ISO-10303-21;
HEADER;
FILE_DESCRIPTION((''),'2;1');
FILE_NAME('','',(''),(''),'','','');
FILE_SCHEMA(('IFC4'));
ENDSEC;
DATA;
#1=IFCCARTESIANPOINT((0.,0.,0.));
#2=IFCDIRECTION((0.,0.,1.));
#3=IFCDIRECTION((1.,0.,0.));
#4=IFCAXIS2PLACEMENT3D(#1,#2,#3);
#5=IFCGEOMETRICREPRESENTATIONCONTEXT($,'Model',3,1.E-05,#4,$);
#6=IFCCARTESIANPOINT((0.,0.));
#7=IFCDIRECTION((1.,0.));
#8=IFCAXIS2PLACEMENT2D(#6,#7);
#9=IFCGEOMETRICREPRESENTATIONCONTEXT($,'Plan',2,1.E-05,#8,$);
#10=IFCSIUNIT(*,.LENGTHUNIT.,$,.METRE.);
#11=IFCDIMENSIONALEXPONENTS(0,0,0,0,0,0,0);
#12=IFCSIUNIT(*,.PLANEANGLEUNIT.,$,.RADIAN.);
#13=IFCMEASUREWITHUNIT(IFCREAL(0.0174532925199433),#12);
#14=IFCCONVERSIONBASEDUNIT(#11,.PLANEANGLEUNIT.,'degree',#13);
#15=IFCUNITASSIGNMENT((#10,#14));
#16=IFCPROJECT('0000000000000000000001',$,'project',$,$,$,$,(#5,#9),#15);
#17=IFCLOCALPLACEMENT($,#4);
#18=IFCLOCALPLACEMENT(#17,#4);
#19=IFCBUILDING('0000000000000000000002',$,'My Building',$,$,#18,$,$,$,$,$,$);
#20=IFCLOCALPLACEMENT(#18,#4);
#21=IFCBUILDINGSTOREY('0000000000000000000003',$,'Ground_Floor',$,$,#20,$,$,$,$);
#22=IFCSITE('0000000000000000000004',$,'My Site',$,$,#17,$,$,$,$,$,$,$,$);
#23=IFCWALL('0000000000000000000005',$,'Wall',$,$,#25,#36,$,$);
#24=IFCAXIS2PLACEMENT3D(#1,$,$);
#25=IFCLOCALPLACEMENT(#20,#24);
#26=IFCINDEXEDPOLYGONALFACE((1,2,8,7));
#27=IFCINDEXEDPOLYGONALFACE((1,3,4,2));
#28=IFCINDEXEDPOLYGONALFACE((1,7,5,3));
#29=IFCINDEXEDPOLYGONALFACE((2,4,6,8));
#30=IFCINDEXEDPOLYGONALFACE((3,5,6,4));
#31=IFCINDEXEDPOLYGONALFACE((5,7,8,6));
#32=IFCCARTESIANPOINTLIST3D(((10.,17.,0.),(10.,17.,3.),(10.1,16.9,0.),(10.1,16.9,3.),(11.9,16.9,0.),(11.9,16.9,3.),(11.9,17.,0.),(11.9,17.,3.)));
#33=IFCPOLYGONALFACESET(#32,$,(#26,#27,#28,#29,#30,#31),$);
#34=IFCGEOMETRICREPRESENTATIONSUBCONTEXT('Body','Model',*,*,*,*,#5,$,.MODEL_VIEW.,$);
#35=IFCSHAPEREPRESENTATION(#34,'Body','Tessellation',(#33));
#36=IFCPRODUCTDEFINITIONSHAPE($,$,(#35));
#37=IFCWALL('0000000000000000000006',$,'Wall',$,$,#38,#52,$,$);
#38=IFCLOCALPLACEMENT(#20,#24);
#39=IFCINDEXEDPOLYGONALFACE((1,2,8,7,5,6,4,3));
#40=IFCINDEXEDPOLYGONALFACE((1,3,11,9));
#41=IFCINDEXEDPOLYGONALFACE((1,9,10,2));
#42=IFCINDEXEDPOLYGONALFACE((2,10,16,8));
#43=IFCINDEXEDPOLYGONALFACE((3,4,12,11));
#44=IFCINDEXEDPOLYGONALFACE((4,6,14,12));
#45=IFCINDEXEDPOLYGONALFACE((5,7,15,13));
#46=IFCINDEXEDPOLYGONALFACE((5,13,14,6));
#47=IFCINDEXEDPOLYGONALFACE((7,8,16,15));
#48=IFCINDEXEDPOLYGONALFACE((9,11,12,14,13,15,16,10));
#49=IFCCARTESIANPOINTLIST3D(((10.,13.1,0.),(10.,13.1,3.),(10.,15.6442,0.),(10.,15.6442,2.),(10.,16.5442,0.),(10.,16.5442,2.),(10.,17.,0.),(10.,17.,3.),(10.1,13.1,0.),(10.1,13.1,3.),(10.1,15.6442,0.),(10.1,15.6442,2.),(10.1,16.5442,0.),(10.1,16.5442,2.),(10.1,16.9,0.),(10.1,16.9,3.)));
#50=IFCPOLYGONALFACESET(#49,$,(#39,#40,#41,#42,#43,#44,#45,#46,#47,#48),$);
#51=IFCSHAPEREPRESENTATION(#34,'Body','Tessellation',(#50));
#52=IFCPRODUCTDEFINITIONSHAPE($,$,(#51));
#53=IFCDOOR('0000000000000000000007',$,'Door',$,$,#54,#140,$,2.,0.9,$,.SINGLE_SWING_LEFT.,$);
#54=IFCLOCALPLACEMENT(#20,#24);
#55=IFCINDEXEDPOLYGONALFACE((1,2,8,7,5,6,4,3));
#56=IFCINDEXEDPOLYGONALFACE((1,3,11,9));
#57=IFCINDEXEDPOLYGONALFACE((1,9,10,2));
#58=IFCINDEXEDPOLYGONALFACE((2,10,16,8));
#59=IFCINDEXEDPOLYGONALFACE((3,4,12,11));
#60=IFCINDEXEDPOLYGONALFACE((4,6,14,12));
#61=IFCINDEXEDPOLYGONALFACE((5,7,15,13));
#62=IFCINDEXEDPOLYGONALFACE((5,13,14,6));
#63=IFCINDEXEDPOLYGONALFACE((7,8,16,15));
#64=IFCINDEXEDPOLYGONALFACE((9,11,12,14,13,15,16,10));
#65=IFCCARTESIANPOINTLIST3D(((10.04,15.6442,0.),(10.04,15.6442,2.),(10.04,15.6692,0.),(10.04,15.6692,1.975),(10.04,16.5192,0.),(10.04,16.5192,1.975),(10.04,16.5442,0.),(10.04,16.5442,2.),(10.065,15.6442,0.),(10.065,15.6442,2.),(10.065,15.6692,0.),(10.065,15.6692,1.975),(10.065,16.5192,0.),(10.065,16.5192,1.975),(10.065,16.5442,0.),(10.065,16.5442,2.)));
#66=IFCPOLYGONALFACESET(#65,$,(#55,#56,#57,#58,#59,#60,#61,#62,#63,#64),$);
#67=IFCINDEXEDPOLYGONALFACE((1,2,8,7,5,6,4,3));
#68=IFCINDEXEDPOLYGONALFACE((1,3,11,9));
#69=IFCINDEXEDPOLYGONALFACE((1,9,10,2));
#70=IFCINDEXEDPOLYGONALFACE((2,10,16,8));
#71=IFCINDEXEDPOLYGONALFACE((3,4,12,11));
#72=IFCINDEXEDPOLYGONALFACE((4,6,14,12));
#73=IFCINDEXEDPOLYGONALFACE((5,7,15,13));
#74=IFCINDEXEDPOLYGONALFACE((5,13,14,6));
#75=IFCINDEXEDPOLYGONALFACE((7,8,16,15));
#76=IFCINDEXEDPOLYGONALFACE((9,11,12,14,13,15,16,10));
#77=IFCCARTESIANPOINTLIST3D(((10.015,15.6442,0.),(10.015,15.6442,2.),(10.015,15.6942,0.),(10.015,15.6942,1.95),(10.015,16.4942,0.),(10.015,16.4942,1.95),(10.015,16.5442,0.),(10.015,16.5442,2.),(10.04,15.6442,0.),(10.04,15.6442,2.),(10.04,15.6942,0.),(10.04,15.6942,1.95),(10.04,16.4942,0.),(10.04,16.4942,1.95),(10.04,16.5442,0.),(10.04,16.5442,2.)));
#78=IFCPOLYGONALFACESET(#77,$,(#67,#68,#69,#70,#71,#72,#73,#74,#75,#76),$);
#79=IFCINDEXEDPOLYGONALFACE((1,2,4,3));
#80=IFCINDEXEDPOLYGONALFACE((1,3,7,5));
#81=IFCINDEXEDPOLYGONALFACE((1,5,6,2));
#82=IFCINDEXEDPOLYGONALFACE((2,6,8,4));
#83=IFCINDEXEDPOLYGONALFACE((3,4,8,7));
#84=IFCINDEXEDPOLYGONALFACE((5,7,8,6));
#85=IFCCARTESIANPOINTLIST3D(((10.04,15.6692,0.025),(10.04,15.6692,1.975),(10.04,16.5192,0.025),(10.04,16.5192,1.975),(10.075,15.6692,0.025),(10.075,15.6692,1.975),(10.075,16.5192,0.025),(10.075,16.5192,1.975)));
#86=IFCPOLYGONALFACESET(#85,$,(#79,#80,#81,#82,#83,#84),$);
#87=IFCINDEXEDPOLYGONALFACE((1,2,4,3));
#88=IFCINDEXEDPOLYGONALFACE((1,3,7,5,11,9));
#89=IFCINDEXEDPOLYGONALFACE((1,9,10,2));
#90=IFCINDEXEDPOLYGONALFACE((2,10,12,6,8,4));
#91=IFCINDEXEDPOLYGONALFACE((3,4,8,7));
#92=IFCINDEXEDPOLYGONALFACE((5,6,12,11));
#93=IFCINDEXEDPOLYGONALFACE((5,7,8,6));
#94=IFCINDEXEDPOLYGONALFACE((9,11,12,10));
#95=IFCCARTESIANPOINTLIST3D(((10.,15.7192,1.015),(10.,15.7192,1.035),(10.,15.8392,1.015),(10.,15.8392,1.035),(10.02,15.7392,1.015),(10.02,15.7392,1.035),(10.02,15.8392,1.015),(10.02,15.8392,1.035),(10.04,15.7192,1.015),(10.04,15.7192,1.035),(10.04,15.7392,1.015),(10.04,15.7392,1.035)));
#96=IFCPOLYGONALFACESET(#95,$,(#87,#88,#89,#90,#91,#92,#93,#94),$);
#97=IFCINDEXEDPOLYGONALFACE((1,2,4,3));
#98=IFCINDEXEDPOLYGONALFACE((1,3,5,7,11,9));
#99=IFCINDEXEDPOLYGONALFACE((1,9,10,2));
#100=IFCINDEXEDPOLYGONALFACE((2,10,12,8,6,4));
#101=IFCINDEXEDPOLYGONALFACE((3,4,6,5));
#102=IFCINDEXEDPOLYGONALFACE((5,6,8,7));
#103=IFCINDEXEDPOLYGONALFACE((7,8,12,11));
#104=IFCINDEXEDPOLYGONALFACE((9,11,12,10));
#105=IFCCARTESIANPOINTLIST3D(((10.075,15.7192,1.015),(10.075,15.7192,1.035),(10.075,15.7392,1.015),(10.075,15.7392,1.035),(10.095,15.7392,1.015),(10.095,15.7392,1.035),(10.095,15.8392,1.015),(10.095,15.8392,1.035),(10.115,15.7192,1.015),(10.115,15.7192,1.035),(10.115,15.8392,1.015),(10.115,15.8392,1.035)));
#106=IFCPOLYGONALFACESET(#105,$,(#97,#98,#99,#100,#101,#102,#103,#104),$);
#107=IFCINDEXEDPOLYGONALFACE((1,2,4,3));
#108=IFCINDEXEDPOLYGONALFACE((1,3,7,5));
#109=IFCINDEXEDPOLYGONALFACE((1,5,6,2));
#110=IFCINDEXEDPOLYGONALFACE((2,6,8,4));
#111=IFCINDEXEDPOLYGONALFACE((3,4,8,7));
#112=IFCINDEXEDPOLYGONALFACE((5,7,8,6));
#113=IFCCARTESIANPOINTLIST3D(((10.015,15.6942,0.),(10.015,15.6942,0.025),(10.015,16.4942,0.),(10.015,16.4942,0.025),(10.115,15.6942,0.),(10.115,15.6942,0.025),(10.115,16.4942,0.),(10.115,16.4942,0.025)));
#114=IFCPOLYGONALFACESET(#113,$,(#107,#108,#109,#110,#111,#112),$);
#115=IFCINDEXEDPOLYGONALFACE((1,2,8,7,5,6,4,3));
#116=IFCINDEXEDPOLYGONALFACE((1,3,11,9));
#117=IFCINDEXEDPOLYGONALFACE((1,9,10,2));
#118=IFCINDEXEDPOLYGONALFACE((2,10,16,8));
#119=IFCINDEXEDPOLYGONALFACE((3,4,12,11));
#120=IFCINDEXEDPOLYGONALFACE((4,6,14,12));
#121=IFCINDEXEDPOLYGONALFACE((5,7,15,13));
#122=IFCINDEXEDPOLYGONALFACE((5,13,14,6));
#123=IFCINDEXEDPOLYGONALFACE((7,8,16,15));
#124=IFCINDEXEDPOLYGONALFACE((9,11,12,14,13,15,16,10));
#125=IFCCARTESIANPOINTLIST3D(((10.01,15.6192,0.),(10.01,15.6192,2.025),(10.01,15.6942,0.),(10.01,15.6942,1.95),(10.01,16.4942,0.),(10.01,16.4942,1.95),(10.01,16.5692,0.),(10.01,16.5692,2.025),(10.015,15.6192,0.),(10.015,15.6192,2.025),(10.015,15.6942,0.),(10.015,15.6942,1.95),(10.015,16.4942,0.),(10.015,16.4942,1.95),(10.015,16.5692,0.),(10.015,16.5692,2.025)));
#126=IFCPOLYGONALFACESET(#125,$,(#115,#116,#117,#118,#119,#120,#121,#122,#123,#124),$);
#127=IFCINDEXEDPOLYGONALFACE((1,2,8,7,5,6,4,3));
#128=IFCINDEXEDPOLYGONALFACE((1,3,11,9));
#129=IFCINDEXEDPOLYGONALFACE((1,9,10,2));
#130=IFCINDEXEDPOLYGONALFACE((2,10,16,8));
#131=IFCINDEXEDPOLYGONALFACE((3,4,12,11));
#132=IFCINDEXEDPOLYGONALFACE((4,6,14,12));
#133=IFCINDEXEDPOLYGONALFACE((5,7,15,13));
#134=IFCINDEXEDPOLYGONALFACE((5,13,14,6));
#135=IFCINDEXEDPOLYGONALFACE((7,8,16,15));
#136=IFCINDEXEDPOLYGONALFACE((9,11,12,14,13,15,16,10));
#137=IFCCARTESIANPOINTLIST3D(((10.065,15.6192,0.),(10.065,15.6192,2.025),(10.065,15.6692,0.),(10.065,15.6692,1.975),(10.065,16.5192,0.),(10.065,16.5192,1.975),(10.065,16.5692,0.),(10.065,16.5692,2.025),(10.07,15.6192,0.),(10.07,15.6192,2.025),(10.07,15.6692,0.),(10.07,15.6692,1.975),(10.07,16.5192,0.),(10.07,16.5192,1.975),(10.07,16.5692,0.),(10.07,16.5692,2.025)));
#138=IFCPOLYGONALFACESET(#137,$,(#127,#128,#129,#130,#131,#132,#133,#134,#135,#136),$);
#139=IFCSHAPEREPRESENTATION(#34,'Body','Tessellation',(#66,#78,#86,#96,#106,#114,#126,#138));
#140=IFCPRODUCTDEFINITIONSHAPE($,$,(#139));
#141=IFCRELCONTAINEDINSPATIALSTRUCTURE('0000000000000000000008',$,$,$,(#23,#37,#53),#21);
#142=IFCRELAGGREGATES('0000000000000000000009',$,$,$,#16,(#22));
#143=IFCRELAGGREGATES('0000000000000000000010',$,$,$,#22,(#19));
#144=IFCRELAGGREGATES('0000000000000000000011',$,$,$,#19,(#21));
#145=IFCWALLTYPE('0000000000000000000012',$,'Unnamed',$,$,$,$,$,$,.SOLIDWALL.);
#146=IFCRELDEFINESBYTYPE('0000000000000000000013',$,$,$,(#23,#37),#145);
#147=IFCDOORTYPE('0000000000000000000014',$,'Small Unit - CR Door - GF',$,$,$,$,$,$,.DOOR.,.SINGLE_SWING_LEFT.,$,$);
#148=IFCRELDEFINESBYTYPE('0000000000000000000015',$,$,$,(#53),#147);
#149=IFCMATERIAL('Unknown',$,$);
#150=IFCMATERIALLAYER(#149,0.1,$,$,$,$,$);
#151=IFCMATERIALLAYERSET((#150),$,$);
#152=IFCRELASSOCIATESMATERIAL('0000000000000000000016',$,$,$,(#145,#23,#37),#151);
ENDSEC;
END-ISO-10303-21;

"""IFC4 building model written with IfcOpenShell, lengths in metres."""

from ifc_helpers import new_model, entity, si_unit, converted_unit, frame, origin_with_axes, origin_2d_with_axis, place, context, subcontext, project, spatial, line, indexed_curve, outline, extrude, shape, source, transform, mapped, material, layer, layer_set, layer_usage, type_object, type_shapes, element, fill, save


model = new_model("IFC4")

# Units and contexts
model_context = context("Model", 3, precision=1e-05, world=origin_with_axes())
plan_context = context("Plan", 2, precision=1e-05, world=origin_2d_with_axis())
body_context_1 = subcontext(model_context, "Body", "Model", "MODEL_VIEW")
body_context_2 = subcontext(plan_context, "Body", "Plan", "PLAN_VIEW")
ifc_project = project(units=[si_unit("LENGTHUNIT", "METRE"), converted_unit("PLANEANGLEUNIT", "degree", entity("IfcReal", 0.0174532925199433), si_unit("PLANEANGLEUNIT", "RADIAN"), dimensions=[0, 0, 0, 0, 0, 0, 0])], contexts=[model_context, plan_context])

# Site, building, storey
site_placement = place(None, origin_with_axes())
site = spatial("IfcSite", under=ifc_project, at=site_placement, Name="My Site")
building_placement = place(site_placement, origin_with_axes())
building = spatial("IfcBuilding", under=site, at=building_placement, Name="My Building")
storey_placement = place(building_placement, origin_with_axes())
storey = spatial("IfcBuildingStorey", under=building, at=storey_placement, Name="Ground_Floor")

# Wall
ifc_material = material(Name="Unknown")
ifc_layer = layer(ifc_material, 0.1)
ifc_layer_set = layer_set([ifc_layer])
wall_type = type_object("IfcWallType", Name="Unnamed", PredefinedType="SOLIDWALL", material=ifc_layer_set)
ifc_layer_usage_1 = layer_usage(ifc_layer_set, "AXIS2", "POSITIVE", 0.0)
wall_1_placement = place(storey_placement, frame((12.0, 17.0, 0.0), z_axis=(0.0, 0.0, 1.0), x_axis=(-1.0, 0.0, 0.0)))
element("IfcWall", 1, at=wall_1_placement, inside=storey, type_object=wall_type, material=ifc_layer_usage_1, Name="Wall", context=body_context_1, shape_type="SweptSolid", body=[
    extrude(outline(indexed_curve([(0.1, 0.0), (0.1, 0.1), (1.9, 0.1), (2.0, 0.0)], segments=[line(1, 2, 3, 4, 1)])), origin_with_axes(), (0.0, 0.0, 1.0), 3.0),
])

# Wall, opening, door
ifc_layer_usage_2 = layer_usage(ifc_layer_set, "AXIS2", "POSITIVE", 0.0)
wall_2_placement = place(storey_placement, frame((10.0, 17.0, 0.0), z_axis=(0.0, 0.0, 1.0), x_axis=(0.0, -1.0, 0.0)))
wall_2 = element("IfcWall", 2, at=wall_2_placement, inside=storey, type_object=wall_type, material=ifc_layer_usage_2, Name="Wall", context=body_context_1, shape_type="SweptSolid", body=[
    extrude(outline(indexed_curve([(0.0, 0.0), (0.1, 0.1), (3.9, 0.1), (3.9, 0.0)], segments=[line(1, 2, 3, 4, 1)])), origin_with_axes(), (0.0, 0.0, 1.0), 3.0),
])
shared_shape_1 = source(origin_with_axes(), body_context_1, "Body", "SweptSolid", [
    extrude(outline(indexed_curve([(0.0, 0.0), (0.9, 0.0), (0.9, 2.0), (0.0, 2.0)], segments=[line(1, 2, 3, 4, 1)])), frame((0.0, -0.6, 0.0), z_axis=(0.0, -1.0, 0.0), x_axis=(1.0, 0.0, 0.0)), (0.0, 0.0, -1.0), 1.2),
])
opening_1_placement = place(wall_2_placement, frame((0.4558, 0.015, 0.0), z_axis=(0.0, 0.0, 1.0), x_axis=(1.0, 0.0, 0.0)))
opening_1 = element("IfcOpeningElement", 3, at=opening_1_placement, cuts=wall_2, PredefinedType="OPENING", context=body_context_1, shape_type="MappedRepresentation", body=[
    mapped(shared_shape_1, transform((0.0, 0.0, 0.0), x_axis=(1.0, 0.0, 0.0), y_axis=(0.0, 1.0, 0.0), z_axis=(0.0, 0.0, 1.0), scale=1.0)),
])
door_type_1 = type_object("IfcDoorType", Name="Small Unit - CR Door - GF", OperationType="SINGLE_SWING_LEFT", PredefinedType="DOOR")
shared_shape_2 = source(origin_with_axes(), body_context_1, "Body", "SweptSolid", [
    extrude(outline(indexed_curve([(0.0, 0.0), (0.0, 2.0), (0.9, 2.0), (0.9, 0.0), (0.875, 0.0), (0.875, 1.975), (0.025, 1.975), (0.025, 0.0)], segments=[line(1, 2, 3, 4, 5, 6, 7, 8, 1)])), frame((0.0, 0.025, 0.0), z_axis=(0.0, -1.0, 0.0), x_axis=(1.0, 0.0, 0.0)), (0.0, 0.0, -1.0), 0.025),
    extrude(outline(indexed_curve([(0.0, 0.0), (0.0, 2.0), (0.9, 2.0), (0.9, 0.0), (0.85, 0.0), (0.85, 1.95), (0.05, 1.95), (0.05, 0.0)], segments=[line(1, 2, 3, 4, 5, 6, 7, 8, 1)])), frame((0.0, 0.0, 0.0), z_axis=(0.0, -1.0, 0.0), x_axis=(1.0, 0.0, 0.0)), (0.0, 0.0, -1.0), 0.025),
    extrude(outline(indexed_curve([(0.0, 0.0), (0.85, 0.0), (0.85, 0.035), (0.0, 0.035)], segments=[line(1, 2, 3, 4, 1)])), frame((0.025, 0.025, 0.025), z_axis=(0.0, 0.0, 1.0), x_axis=(1.0, 0.0, 0.0)), (0.0, 0.0, 1.0), 1.95),
    extrude(outline(indexed_curve([(0.0, 0.0), (0.0, -0.04), (-0.12, -0.04), (-0.12, -0.02), (-0.02, -0.02), (-0.02, 0.0)], segments=[line(1, 2, 3, 4, 5, 6, 1)])), frame((0.825, 0.025, 1.015), z_axis=(0.0, 0.0, 1.0), x_axis=(1.0, 0.0, 0.0)), (0.0, 0.0, 1.0), 0.02),
    extrude(outline(indexed_curve([(0.0, 0.0), (0.0, 0.04), (-0.12, 0.04), (-0.12, 0.02), (-0.02, 0.02), (-0.02, 0.0)], segments=[line(1, 2, 3, 4, 5, 6, 1)])), frame((0.825, 0.06, 1.015), z_axis=(0.0, 0.0, 1.0), x_axis=(1.0, 0.0, 0.0)), (0.0, 0.0, 1.0), 0.02),
    extrude(outline(indexed_curve([(0.0, 0.0), (0.8, 0.0), (0.8, 0.1), (0.0, 0.1)], segments=[line(1, 2, 3, 4, 1)])), frame((0.05, 0.0, 0.0), z_axis=(0.0, 0.0, 1.0), x_axis=(1.0, 0.0, 0.0)), (0.0, 0.0, 1.0), 0.025),
    extrude(outline(indexed_curve([(0.0, 0.0), (0.0, 2.025), (0.95, 2.025), (0.95, 0.0), (0.875, 0.0), (0.875, 1.95), (0.075, 1.95), (0.075, 0.0)], segments=[line(1, 2, 3, 4, 5, 6, 7, 8, 1)])), frame((-0.025, -0.005, 0.0), z_axis=(0.0, -1.0, 0.0), x_axis=(1.0, 0.0, 0.0)), (0.0, 0.0, -1.0), 0.005),
    extrude(outline(indexed_curve([(0.0, 0.0), (0.0, 2.025), (0.95, 2.025), (0.95, 0.0), (0.9, 0.0), (0.9, 1.975), (0.05, 1.975), (0.05, 0.0)], segments=[line(1, 2, 3, 4, 5, 6, 7, 8, 1)])), frame((-0.025, 0.05, 0.0), z_axis=(0.0, -1.0, 0.0), x_axis=(1.0, 0.0, 0.0)), (0.0, 0.0, -1.0), 0.005),
])
shared_shape_3 = source(origin_with_axes(), body_context_2, "Body", "Curve2D", [
    entity("IfcIndexedPolyCurve", entity("IfcCartesianPointList2D", [[0.0, 0.0], [0.0, 0.05], [0.025, 0.05], [0.025, 0.025], [0.05, 0.025], [0.05, 0.0]]), [entity("IfcLineIndex", [1, 2, 3, 4, 5, 6, 1])]),
    entity("IfcIndexedPolyCurve", entity("IfcCartesianPointList2D", [[0.9, 0.0], [0.9, 0.05], [0.875, 0.05], [0.875, 0.025], [0.85, 0.025], [0.85, 0.0]]), [entity("IfcLineIndex", [1, 2, 3, 4, 5, 6, 1])]),
    entity("IfcTrimmedCurve", entity("IfcEllipse", entity("IfcAxis2Placement2D", entity("IfcCartesianPoint", [0.06, 0.05]), entity("IfcDirection", [1.0, 0.0])), 0.815, 0.85), [entity("IfcCartesianPoint", [0.875, 0.05])], [entity("IfcCartesianPoint", [0.06, 0.9])], True, "CARTESIAN"),
    entity("IfcIndexedPolyCurve", entity("IfcCartesianPointList2D", [[0.025, 0.05], [0.06, 0.05], [0.06, 0.9], [0.025, 0.9]]), [entity("IfcLineIndex", [1, 2, 3, 4, 1])]),
])
type_shapes(door_type_1, [shared_shape_2, shared_shape_3])
door_1_placement = place(opening_1_placement, frame((0.0, 0.0, 0.0), z_axis=(0.0, 0.0, 1.0), x_axis=(1.0, 0.0, 0.0)))
door_1 = element("IfcDoor", 4, at=door_1_placement, inside=storey, type_object=door_type_1, Name="Door", OperationType="SINGLE_SWING_LEFT", OverallHeight=2.0, OverallWidth=0.9, shapes=[
    shape(body_context_1, "Body", "MappedRepresentation", [mapped(shared_shape_2, transform((0.0, 0.0, 0.0), x_axis=(1.0, 0.0, 0.0), y_axis=(0.0, 1.0, 0.0), z_axis=(0.0, 0.0, 1.0), scale=1.0))]),
    shape(body_context_2, "Body", "MappedRepresentation", [mapped(shared_shape_3, transform((0.0, 0.0, 0.0), x_axis=(1.0, 0.0, 0.0), y_axis=(0.0, 1.0, 0.0), z_axis=(0.0, 0.0, 1.0), scale=1.0))]),
])
fill(opening_1, door_1)

save(model, "model.ifc")
